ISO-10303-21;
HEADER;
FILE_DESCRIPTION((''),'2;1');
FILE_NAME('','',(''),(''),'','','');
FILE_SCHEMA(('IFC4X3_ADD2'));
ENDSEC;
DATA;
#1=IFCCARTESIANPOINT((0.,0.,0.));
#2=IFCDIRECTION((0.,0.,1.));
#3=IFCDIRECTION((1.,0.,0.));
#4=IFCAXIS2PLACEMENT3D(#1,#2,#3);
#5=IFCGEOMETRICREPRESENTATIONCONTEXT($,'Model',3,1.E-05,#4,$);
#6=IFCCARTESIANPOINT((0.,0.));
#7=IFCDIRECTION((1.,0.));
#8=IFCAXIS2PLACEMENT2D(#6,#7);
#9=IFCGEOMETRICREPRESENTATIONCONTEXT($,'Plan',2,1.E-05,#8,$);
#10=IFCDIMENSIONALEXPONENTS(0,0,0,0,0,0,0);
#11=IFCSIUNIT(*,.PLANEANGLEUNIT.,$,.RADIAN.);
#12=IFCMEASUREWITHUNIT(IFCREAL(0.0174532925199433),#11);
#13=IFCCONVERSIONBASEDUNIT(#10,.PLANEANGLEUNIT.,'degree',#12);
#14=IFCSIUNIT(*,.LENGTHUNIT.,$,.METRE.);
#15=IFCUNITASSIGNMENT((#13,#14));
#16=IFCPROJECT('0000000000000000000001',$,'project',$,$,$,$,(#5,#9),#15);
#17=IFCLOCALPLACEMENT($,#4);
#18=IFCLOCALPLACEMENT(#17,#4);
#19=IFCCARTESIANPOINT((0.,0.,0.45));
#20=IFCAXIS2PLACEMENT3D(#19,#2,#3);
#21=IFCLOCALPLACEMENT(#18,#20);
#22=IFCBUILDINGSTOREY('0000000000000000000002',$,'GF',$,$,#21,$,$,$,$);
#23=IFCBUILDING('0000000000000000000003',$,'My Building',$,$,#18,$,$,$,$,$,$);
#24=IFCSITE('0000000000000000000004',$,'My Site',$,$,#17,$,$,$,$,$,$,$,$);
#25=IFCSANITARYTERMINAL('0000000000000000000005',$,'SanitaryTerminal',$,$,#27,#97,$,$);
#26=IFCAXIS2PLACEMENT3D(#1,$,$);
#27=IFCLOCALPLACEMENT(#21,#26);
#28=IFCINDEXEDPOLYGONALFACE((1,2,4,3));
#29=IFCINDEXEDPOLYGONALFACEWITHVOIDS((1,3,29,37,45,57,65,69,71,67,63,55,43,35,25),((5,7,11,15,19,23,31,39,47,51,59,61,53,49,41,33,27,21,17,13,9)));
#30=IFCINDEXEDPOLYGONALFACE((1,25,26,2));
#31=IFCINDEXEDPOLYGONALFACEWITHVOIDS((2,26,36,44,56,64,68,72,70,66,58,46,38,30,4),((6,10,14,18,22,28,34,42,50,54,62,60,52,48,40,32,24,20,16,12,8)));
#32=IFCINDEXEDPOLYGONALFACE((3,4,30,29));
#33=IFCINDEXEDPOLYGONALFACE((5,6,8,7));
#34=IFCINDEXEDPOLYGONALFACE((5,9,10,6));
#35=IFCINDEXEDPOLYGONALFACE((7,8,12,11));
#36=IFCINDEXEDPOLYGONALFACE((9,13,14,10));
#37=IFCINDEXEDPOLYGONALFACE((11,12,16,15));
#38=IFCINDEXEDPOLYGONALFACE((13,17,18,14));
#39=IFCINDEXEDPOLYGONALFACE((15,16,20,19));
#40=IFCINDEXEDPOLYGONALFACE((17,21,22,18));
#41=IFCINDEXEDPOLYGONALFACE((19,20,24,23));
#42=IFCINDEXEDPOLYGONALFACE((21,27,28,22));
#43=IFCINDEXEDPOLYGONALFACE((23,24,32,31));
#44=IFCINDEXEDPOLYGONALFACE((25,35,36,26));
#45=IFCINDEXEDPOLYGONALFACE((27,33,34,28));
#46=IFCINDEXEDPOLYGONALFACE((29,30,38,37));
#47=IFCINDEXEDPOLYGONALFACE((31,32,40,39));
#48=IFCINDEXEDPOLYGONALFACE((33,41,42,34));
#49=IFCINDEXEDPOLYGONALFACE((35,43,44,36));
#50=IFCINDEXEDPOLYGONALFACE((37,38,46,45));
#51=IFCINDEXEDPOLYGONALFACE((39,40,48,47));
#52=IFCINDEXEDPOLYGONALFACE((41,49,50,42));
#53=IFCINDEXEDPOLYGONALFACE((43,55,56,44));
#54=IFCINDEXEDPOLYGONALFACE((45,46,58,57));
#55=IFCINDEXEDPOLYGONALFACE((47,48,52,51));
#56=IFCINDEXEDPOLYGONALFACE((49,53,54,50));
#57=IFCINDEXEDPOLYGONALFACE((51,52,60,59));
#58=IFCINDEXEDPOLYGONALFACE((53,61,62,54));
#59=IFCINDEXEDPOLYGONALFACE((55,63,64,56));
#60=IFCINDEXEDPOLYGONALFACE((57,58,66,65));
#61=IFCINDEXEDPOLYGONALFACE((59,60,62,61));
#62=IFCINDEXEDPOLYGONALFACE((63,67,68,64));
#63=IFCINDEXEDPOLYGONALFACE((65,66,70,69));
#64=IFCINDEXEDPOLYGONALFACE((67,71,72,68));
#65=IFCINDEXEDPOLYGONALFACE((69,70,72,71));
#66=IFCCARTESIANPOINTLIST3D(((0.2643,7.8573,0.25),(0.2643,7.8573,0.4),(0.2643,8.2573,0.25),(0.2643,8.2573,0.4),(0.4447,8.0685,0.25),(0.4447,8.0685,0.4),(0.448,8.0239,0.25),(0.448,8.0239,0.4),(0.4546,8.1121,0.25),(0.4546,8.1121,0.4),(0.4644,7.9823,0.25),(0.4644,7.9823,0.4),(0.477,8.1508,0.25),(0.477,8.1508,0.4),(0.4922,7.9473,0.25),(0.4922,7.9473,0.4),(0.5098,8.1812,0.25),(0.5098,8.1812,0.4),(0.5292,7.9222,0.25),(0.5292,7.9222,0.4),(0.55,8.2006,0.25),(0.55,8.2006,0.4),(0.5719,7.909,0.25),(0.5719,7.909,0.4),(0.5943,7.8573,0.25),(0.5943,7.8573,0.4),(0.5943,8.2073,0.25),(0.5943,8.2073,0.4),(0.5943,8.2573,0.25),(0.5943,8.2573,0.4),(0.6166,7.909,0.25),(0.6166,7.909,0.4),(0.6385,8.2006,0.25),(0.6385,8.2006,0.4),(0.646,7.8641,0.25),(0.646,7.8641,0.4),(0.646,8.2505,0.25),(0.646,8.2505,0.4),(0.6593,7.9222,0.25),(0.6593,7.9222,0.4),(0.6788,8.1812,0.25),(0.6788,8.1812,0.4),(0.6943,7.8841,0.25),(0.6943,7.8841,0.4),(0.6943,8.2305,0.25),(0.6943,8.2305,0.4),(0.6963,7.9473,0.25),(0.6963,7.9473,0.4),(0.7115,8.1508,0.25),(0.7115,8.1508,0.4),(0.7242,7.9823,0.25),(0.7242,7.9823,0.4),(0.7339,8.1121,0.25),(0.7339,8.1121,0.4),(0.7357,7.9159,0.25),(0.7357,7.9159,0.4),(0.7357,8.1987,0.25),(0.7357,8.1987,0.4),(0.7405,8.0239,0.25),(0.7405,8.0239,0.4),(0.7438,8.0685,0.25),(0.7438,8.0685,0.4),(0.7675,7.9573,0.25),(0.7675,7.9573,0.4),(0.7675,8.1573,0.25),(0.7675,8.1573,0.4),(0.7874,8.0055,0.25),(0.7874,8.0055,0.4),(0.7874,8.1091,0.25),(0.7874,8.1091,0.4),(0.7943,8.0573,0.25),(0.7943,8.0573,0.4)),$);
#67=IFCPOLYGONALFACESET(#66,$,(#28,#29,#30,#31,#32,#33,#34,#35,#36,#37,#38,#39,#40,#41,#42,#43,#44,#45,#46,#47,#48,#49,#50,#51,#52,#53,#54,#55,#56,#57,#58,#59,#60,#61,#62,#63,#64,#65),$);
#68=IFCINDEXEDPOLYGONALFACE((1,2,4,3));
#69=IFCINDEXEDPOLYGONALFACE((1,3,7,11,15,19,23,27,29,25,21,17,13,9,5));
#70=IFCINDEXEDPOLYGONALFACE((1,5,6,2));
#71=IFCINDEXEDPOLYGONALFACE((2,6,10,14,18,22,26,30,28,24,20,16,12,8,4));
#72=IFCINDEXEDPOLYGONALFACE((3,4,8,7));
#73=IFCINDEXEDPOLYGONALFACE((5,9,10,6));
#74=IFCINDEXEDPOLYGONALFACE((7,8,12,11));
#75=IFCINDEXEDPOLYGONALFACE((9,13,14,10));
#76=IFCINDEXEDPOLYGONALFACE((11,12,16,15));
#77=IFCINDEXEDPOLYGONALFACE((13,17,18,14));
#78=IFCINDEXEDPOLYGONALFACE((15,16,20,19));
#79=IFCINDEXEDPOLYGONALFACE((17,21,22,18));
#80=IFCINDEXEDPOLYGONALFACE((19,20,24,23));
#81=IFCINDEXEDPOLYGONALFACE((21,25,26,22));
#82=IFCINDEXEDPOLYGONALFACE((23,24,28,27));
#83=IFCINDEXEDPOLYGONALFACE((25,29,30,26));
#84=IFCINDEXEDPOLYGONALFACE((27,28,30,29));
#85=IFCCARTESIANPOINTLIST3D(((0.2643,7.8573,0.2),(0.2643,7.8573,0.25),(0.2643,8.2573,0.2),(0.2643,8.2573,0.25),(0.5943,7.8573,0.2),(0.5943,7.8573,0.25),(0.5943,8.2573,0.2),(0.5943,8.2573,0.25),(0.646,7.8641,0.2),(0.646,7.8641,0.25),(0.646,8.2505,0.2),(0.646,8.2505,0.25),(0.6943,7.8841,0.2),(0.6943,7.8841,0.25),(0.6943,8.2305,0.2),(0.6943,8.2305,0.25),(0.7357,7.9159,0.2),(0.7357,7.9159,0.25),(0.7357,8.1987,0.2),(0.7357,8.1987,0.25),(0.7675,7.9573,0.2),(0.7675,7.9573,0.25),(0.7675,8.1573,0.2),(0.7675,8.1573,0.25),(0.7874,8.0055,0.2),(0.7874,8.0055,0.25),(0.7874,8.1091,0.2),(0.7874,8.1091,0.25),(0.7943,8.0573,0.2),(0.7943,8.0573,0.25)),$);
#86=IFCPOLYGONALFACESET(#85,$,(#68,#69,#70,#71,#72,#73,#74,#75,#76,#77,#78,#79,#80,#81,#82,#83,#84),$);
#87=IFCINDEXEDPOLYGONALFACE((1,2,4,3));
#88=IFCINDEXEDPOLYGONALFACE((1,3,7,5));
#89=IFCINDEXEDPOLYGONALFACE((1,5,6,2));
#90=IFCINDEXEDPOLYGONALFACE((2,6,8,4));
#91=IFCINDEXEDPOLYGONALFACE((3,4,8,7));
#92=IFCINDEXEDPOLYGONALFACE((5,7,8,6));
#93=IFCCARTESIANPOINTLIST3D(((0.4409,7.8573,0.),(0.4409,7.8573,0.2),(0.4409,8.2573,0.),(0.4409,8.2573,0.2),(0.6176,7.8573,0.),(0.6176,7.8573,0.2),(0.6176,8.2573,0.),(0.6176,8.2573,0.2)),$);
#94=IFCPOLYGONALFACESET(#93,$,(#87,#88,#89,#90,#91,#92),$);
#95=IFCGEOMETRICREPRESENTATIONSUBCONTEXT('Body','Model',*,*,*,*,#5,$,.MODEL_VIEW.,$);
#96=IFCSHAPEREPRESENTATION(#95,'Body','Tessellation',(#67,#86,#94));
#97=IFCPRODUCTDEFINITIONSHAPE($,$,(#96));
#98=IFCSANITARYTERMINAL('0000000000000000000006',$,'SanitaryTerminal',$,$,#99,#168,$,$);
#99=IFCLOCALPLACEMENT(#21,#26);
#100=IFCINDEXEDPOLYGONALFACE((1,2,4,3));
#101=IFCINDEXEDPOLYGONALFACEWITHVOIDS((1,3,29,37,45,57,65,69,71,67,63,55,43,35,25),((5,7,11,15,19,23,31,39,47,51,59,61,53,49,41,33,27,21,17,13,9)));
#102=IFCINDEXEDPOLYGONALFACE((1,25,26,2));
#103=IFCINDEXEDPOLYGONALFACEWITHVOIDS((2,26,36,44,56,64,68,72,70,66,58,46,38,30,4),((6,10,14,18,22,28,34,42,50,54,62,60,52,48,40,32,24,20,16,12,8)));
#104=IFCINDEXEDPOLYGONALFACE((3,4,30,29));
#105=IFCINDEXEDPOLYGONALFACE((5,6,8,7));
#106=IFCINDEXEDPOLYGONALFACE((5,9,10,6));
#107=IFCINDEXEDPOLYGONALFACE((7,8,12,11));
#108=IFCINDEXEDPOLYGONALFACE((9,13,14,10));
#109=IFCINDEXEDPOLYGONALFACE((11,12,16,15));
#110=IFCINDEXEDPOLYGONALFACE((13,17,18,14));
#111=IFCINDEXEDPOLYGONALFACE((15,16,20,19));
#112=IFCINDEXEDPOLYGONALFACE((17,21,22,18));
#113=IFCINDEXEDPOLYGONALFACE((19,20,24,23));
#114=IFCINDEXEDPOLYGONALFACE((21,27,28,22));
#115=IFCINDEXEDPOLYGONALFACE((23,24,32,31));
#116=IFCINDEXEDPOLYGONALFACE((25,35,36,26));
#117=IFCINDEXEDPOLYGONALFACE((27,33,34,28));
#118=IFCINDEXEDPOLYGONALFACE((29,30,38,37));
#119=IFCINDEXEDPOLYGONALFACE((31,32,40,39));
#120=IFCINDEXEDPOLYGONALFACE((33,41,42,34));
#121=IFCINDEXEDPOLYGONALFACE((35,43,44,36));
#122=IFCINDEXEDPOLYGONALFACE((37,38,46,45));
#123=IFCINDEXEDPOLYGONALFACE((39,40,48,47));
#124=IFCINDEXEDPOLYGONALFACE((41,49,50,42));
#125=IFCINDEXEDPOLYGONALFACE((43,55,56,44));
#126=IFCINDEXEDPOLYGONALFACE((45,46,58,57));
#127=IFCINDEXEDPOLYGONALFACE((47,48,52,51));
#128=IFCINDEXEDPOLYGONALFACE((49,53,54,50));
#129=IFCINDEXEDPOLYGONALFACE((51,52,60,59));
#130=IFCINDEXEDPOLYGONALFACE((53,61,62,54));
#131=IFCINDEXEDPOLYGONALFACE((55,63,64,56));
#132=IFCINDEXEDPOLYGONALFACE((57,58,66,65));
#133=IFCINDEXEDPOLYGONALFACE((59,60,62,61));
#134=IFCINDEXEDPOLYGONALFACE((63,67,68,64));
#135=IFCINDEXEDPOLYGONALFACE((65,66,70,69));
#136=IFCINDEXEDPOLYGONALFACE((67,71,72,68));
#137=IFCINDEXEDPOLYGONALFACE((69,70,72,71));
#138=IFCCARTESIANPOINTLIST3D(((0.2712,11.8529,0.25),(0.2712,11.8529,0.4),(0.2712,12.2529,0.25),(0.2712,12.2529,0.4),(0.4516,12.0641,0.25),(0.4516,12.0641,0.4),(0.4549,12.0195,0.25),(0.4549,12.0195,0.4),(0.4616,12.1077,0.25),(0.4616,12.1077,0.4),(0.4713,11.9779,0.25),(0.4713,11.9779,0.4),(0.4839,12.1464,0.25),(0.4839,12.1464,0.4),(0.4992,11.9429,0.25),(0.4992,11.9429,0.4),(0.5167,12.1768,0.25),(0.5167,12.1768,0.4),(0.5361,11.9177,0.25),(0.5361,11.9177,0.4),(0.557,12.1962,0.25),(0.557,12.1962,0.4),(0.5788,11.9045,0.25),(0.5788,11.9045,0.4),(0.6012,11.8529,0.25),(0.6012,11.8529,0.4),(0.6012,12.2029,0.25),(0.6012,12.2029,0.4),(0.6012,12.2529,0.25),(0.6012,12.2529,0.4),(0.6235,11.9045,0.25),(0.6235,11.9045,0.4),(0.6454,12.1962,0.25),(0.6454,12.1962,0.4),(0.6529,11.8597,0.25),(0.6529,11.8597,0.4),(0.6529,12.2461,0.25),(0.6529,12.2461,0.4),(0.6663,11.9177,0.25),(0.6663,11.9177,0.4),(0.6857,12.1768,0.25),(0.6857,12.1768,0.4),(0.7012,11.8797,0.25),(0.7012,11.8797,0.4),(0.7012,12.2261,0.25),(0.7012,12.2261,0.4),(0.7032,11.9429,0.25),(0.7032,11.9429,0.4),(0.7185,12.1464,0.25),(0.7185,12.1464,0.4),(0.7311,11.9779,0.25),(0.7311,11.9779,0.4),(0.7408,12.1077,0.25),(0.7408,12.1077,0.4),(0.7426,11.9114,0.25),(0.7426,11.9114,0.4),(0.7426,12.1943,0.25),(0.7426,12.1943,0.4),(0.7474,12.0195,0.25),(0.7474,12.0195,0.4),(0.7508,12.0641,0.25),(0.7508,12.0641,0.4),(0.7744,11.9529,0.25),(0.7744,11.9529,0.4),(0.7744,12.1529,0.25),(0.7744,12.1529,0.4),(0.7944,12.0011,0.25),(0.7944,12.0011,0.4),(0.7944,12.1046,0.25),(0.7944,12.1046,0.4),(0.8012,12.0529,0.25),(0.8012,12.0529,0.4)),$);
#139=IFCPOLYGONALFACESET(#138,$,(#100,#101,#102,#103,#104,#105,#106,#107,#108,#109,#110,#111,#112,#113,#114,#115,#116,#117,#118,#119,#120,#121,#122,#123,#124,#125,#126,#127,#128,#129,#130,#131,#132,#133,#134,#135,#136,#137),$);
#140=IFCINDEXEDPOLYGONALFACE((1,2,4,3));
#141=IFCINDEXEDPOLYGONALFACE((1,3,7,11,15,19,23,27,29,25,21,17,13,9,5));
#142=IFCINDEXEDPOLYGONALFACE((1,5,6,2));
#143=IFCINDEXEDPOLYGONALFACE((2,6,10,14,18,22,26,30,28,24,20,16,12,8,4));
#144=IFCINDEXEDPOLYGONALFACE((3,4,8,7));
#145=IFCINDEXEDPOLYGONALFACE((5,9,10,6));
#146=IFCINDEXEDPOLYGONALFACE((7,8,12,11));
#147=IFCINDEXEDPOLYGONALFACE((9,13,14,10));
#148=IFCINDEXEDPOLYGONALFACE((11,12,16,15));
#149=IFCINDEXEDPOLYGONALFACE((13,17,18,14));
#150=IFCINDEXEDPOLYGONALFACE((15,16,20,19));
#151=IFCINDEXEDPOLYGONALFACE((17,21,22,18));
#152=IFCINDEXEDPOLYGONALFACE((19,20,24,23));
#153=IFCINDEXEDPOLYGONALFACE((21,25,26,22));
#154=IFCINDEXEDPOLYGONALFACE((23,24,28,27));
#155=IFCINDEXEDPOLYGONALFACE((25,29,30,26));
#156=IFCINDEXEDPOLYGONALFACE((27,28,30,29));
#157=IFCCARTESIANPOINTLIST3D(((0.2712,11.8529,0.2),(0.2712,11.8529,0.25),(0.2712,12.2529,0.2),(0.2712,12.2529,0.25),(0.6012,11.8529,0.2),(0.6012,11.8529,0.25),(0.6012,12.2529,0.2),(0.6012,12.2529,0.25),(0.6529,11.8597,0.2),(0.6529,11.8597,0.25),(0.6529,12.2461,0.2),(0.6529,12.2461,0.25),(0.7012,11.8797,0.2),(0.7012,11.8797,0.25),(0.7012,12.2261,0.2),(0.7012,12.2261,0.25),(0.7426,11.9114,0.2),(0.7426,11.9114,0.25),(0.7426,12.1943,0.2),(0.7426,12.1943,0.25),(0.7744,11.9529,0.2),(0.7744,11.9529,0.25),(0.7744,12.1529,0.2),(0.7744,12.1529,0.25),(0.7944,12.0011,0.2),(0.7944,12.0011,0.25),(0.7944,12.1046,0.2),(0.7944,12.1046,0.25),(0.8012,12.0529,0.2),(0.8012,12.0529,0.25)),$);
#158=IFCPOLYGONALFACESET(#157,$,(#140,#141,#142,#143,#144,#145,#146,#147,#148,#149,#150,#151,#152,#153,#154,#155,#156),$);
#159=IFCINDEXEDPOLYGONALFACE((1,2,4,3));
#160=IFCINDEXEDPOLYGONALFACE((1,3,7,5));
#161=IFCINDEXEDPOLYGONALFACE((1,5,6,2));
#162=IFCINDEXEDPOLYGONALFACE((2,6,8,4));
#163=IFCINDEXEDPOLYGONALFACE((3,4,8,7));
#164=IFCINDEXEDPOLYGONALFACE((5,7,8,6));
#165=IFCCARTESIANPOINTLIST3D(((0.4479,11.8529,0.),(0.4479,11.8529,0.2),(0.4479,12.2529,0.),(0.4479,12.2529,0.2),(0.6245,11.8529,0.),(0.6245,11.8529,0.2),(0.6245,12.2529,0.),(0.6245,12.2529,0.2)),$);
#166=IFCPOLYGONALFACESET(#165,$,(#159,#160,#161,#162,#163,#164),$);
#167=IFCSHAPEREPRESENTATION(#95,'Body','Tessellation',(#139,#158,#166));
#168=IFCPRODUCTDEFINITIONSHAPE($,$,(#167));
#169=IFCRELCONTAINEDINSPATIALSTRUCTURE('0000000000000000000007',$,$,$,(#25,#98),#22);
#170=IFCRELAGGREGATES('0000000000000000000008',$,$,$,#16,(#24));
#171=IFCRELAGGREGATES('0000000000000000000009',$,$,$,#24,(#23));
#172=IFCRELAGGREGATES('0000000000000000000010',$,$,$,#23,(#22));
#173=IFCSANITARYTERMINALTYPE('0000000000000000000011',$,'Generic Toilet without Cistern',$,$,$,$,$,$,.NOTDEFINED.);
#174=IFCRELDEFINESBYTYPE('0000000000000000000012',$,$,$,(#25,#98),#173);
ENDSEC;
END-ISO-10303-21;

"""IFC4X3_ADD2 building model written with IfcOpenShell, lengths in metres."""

from ifc_helpers import new_model, entity, si_unit, converted_unit, frame, frame_2d, origin_with_axes, origin_2d_with_axis, place, context, subcontext, project, spatial, line, arc, indexed_curve, circle_curve, outline, extrude, shape, source, transform, mapped, type_object, type_shapes, element, save


model = new_model("IFC4X3_ADD2")

# Units and contexts
model_context = context("Model", 3, precision=1e-05, world=origin_with_axes())
plan_context = context("Plan", 2, precision=1e-05, world=origin_2d_with_axis())
body_context_1 = subcontext(model_context, "Body", "Model", "MODEL_VIEW")
body_context_2 = subcontext(plan_context, "Body", "Plan", "PLAN_VIEW")
ifc_project = project(units=[converted_unit("PLANEANGLEUNIT", "degree", entity("IfcReal", 0.0174532925199433), si_unit("PLANEANGLEUNIT", "RADIAN"), dimensions=[0, 0, 0, 0, 0, 0, 0]), si_unit("LENGTHUNIT", "METRE")], contexts=[model_context, plan_context])

# Site, building, storey
site_placement = place(None, origin_with_axes())
site = spatial("IfcSite", under=ifc_project, at=site_placement, Name="My Site")
building_placement = place(site_placement, origin_with_axes())
building = spatial("IfcBuilding", under=site, at=building_placement, Name="My Building")
storey_placement = place(building_placement, frame((0.0, 0.0, 0.45), z_axis=(0.0, 0.0, 1.0), x_axis=(1.0, 0.0, 0.0)))
storey = spatial("IfcBuildingStorey", under=building, at=storey_placement, Name="GF")

# Sanitary terminals
sanitary_terminal_type_1 = type_object("IfcSanitaryTerminalType", Name="Generic Toilet without Cistern", PredefinedType="NOTDEFINED")
shared_shape_1 = source(origin_with_axes(), body_context_1, "Body", "SweptSolid", [
    extrude(outline(indexed_curve([(-0.2, 0.0), (0.2, 0.0), (0.2, -0.33), (0.1414, -0.4714), (0.0, -0.53), (-0.1414, -0.4714), (-0.2, -0.33)], segments=[line(1, 2), line(2, 3), arc(3, 4, 5), arc(5, 6, 7), line(7, 1)]), holes=[circle_curve(frame_2d((0.0, -0.33)), 0.15)]), frame((0.0, 0.0, 0.25), z_axis=(0.0, 0.0, 1.0), x_axis=(1.0, 0.0, 0.0)), (0.0, 0.0, 1.0), 0.15),
    extrude(outline(indexed_curve([(-0.2, 0.0), (0.2, 0.0), (0.2, -0.33), (0.1414, -0.4714), (0.0, -0.53), (-0.1414, -0.4714), (-0.2, -0.33)], segments=[line(1, 2), line(2, 3), arc(3, 4, 5), arc(5, 6, 7), line(7, 1)])), frame((0.0, 0.0, 0.2), z_axis=(0.0, 0.0, 1.0), x_axis=(1.0, 0.0, 0.0)), (0.0, 0.0, 1.0), 0.05),
    extrude(outline(indexed_curve([(-0.2, -0.1767), (0.2, -0.1767), (0.2, -0.3533), (-0.2, -0.3533)], segments=[line(1, 2, 3, 4, 1)])), origin_with_axes(), (0.0, 0.0, 1.0), 0.2),
])
shared_shape_2 = source(origin_with_axes(), body_context_2, "Body", "Annotation2D", [
    entity("IfcGeometricCurveSet", [entity("IfcIndexedPolyCurve", entity("IfcCartesianPointList2D", [[-0.1068, -0.124], [-0.0957, -0.1129], [-0.0804, -0.1088], [0.0804, -0.1088], [0.0957, -0.1129], [0.1068, -0.124], [0.1109, -0.1393], [0.1109, -0.3476], [0.1025, -0.3926], [0.0784, -0.4308], [0.0424, -0.4563], [0.0, -0.4652], [-0.0424, -0.4563], [-0.0784, -0.4308], [-0.1025, -0.3926], [-0.1109, -0.3476], [-0.1109, -0.1393]]), [entity("IfcLineIndex", [1, 2, 3, 4, 5, 6, 7, 8, 9, 10, 11, 12, 13, 14, 15, 16, 17, 1])]), entity("IfcIndexedPolyCurve", entity("IfcCartesianPointList2D", [[-0.1962, -0.2314], [-0.1848, -0.301], [-0.1764, -0.3339], [-0.1663, -0.3651], [-0.1546, -0.3944], [-0.1414, -0.4213], [-0.1269, -0.4458], [-0.1111, -0.4675], [-0.0943, -0.4862], [-0.0765, -0.5018], [-0.0581, -0.514], [-0.039, -0.5229], [-0.0196, -0.5282], [0.0, -0.53], [0.0196, -0.5282], [0.039, -0.5229], [0.0581, -0.514], [0.0765, -0.5018], [0.0943, -0.4862], [0.1111, -0.4675], [0.1269, -0.4458], [0.1414, -0.4213], [0.1546, -0.3944], [0.1663, -0.3651], [0.1764, -0.3339], [0.1848, -0.301], [0.1962, -0.2314], [0.2, -0.159], [0.1872, 0.0], [-0.1872, 0.0], [-0.2, -0.159]]), [entity("IfcLineIndex", [1, 2, 3, 4, 5, 6, 7, 8, 9, 10, 11, 12, 13, 14, 15, 16, 17, 18, 19, 20, 21, 22, 23, 24, 25, 26, 27, 28, 29, 30, 31, 1])])]),
])
type_shapes(sanitary_terminal_type_1, [shared_shape_1, shared_shape_2])
for number, where, z_axis, x_axis, name in (
    (1, (0.2643, 8.0573, 0.0), (0.0, 0.0, 1.0), (0.000001, 1.0, 0.0), "SanitaryTerminal"),
    (2, (0.2712, 12.0529, 0.0), (0.0, 0.0, 1.0), (0.0, 1.0, 0.0), "SanitaryTerminal"),
):
    element("IfcSanitaryTerminal", number, at=place(storey_placement, frame(where, z_axis=z_axis, x_axis=x_axis)), inside=storey, type_object=sanitary_terminal_type_1, Name=name, shapes=[
        shape(body_context_1, "Body", "MappedRepresentation", [mapped(shared_shape_1, transform((0.0, 0.0, 0.0), x_axis=(1.0, 0.0, 0.0), y_axis=(0.0, 1.0, 0.0), z_axis=(0.0, 0.0, 1.0), scale=1.0))]),
        shape(body_context_2, "Body", "MappedRepresentation", [mapped(shared_shape_2, transform((0.0, 0.0, 0.0), x_axis=(1.0, 0.0, 0.0), y_axis=(0.0, 1.0, 0.0), z_axis=(0.0, 0.0, 1.0), scale=1.0))]),
    ])

save(model, "model.ifc")
